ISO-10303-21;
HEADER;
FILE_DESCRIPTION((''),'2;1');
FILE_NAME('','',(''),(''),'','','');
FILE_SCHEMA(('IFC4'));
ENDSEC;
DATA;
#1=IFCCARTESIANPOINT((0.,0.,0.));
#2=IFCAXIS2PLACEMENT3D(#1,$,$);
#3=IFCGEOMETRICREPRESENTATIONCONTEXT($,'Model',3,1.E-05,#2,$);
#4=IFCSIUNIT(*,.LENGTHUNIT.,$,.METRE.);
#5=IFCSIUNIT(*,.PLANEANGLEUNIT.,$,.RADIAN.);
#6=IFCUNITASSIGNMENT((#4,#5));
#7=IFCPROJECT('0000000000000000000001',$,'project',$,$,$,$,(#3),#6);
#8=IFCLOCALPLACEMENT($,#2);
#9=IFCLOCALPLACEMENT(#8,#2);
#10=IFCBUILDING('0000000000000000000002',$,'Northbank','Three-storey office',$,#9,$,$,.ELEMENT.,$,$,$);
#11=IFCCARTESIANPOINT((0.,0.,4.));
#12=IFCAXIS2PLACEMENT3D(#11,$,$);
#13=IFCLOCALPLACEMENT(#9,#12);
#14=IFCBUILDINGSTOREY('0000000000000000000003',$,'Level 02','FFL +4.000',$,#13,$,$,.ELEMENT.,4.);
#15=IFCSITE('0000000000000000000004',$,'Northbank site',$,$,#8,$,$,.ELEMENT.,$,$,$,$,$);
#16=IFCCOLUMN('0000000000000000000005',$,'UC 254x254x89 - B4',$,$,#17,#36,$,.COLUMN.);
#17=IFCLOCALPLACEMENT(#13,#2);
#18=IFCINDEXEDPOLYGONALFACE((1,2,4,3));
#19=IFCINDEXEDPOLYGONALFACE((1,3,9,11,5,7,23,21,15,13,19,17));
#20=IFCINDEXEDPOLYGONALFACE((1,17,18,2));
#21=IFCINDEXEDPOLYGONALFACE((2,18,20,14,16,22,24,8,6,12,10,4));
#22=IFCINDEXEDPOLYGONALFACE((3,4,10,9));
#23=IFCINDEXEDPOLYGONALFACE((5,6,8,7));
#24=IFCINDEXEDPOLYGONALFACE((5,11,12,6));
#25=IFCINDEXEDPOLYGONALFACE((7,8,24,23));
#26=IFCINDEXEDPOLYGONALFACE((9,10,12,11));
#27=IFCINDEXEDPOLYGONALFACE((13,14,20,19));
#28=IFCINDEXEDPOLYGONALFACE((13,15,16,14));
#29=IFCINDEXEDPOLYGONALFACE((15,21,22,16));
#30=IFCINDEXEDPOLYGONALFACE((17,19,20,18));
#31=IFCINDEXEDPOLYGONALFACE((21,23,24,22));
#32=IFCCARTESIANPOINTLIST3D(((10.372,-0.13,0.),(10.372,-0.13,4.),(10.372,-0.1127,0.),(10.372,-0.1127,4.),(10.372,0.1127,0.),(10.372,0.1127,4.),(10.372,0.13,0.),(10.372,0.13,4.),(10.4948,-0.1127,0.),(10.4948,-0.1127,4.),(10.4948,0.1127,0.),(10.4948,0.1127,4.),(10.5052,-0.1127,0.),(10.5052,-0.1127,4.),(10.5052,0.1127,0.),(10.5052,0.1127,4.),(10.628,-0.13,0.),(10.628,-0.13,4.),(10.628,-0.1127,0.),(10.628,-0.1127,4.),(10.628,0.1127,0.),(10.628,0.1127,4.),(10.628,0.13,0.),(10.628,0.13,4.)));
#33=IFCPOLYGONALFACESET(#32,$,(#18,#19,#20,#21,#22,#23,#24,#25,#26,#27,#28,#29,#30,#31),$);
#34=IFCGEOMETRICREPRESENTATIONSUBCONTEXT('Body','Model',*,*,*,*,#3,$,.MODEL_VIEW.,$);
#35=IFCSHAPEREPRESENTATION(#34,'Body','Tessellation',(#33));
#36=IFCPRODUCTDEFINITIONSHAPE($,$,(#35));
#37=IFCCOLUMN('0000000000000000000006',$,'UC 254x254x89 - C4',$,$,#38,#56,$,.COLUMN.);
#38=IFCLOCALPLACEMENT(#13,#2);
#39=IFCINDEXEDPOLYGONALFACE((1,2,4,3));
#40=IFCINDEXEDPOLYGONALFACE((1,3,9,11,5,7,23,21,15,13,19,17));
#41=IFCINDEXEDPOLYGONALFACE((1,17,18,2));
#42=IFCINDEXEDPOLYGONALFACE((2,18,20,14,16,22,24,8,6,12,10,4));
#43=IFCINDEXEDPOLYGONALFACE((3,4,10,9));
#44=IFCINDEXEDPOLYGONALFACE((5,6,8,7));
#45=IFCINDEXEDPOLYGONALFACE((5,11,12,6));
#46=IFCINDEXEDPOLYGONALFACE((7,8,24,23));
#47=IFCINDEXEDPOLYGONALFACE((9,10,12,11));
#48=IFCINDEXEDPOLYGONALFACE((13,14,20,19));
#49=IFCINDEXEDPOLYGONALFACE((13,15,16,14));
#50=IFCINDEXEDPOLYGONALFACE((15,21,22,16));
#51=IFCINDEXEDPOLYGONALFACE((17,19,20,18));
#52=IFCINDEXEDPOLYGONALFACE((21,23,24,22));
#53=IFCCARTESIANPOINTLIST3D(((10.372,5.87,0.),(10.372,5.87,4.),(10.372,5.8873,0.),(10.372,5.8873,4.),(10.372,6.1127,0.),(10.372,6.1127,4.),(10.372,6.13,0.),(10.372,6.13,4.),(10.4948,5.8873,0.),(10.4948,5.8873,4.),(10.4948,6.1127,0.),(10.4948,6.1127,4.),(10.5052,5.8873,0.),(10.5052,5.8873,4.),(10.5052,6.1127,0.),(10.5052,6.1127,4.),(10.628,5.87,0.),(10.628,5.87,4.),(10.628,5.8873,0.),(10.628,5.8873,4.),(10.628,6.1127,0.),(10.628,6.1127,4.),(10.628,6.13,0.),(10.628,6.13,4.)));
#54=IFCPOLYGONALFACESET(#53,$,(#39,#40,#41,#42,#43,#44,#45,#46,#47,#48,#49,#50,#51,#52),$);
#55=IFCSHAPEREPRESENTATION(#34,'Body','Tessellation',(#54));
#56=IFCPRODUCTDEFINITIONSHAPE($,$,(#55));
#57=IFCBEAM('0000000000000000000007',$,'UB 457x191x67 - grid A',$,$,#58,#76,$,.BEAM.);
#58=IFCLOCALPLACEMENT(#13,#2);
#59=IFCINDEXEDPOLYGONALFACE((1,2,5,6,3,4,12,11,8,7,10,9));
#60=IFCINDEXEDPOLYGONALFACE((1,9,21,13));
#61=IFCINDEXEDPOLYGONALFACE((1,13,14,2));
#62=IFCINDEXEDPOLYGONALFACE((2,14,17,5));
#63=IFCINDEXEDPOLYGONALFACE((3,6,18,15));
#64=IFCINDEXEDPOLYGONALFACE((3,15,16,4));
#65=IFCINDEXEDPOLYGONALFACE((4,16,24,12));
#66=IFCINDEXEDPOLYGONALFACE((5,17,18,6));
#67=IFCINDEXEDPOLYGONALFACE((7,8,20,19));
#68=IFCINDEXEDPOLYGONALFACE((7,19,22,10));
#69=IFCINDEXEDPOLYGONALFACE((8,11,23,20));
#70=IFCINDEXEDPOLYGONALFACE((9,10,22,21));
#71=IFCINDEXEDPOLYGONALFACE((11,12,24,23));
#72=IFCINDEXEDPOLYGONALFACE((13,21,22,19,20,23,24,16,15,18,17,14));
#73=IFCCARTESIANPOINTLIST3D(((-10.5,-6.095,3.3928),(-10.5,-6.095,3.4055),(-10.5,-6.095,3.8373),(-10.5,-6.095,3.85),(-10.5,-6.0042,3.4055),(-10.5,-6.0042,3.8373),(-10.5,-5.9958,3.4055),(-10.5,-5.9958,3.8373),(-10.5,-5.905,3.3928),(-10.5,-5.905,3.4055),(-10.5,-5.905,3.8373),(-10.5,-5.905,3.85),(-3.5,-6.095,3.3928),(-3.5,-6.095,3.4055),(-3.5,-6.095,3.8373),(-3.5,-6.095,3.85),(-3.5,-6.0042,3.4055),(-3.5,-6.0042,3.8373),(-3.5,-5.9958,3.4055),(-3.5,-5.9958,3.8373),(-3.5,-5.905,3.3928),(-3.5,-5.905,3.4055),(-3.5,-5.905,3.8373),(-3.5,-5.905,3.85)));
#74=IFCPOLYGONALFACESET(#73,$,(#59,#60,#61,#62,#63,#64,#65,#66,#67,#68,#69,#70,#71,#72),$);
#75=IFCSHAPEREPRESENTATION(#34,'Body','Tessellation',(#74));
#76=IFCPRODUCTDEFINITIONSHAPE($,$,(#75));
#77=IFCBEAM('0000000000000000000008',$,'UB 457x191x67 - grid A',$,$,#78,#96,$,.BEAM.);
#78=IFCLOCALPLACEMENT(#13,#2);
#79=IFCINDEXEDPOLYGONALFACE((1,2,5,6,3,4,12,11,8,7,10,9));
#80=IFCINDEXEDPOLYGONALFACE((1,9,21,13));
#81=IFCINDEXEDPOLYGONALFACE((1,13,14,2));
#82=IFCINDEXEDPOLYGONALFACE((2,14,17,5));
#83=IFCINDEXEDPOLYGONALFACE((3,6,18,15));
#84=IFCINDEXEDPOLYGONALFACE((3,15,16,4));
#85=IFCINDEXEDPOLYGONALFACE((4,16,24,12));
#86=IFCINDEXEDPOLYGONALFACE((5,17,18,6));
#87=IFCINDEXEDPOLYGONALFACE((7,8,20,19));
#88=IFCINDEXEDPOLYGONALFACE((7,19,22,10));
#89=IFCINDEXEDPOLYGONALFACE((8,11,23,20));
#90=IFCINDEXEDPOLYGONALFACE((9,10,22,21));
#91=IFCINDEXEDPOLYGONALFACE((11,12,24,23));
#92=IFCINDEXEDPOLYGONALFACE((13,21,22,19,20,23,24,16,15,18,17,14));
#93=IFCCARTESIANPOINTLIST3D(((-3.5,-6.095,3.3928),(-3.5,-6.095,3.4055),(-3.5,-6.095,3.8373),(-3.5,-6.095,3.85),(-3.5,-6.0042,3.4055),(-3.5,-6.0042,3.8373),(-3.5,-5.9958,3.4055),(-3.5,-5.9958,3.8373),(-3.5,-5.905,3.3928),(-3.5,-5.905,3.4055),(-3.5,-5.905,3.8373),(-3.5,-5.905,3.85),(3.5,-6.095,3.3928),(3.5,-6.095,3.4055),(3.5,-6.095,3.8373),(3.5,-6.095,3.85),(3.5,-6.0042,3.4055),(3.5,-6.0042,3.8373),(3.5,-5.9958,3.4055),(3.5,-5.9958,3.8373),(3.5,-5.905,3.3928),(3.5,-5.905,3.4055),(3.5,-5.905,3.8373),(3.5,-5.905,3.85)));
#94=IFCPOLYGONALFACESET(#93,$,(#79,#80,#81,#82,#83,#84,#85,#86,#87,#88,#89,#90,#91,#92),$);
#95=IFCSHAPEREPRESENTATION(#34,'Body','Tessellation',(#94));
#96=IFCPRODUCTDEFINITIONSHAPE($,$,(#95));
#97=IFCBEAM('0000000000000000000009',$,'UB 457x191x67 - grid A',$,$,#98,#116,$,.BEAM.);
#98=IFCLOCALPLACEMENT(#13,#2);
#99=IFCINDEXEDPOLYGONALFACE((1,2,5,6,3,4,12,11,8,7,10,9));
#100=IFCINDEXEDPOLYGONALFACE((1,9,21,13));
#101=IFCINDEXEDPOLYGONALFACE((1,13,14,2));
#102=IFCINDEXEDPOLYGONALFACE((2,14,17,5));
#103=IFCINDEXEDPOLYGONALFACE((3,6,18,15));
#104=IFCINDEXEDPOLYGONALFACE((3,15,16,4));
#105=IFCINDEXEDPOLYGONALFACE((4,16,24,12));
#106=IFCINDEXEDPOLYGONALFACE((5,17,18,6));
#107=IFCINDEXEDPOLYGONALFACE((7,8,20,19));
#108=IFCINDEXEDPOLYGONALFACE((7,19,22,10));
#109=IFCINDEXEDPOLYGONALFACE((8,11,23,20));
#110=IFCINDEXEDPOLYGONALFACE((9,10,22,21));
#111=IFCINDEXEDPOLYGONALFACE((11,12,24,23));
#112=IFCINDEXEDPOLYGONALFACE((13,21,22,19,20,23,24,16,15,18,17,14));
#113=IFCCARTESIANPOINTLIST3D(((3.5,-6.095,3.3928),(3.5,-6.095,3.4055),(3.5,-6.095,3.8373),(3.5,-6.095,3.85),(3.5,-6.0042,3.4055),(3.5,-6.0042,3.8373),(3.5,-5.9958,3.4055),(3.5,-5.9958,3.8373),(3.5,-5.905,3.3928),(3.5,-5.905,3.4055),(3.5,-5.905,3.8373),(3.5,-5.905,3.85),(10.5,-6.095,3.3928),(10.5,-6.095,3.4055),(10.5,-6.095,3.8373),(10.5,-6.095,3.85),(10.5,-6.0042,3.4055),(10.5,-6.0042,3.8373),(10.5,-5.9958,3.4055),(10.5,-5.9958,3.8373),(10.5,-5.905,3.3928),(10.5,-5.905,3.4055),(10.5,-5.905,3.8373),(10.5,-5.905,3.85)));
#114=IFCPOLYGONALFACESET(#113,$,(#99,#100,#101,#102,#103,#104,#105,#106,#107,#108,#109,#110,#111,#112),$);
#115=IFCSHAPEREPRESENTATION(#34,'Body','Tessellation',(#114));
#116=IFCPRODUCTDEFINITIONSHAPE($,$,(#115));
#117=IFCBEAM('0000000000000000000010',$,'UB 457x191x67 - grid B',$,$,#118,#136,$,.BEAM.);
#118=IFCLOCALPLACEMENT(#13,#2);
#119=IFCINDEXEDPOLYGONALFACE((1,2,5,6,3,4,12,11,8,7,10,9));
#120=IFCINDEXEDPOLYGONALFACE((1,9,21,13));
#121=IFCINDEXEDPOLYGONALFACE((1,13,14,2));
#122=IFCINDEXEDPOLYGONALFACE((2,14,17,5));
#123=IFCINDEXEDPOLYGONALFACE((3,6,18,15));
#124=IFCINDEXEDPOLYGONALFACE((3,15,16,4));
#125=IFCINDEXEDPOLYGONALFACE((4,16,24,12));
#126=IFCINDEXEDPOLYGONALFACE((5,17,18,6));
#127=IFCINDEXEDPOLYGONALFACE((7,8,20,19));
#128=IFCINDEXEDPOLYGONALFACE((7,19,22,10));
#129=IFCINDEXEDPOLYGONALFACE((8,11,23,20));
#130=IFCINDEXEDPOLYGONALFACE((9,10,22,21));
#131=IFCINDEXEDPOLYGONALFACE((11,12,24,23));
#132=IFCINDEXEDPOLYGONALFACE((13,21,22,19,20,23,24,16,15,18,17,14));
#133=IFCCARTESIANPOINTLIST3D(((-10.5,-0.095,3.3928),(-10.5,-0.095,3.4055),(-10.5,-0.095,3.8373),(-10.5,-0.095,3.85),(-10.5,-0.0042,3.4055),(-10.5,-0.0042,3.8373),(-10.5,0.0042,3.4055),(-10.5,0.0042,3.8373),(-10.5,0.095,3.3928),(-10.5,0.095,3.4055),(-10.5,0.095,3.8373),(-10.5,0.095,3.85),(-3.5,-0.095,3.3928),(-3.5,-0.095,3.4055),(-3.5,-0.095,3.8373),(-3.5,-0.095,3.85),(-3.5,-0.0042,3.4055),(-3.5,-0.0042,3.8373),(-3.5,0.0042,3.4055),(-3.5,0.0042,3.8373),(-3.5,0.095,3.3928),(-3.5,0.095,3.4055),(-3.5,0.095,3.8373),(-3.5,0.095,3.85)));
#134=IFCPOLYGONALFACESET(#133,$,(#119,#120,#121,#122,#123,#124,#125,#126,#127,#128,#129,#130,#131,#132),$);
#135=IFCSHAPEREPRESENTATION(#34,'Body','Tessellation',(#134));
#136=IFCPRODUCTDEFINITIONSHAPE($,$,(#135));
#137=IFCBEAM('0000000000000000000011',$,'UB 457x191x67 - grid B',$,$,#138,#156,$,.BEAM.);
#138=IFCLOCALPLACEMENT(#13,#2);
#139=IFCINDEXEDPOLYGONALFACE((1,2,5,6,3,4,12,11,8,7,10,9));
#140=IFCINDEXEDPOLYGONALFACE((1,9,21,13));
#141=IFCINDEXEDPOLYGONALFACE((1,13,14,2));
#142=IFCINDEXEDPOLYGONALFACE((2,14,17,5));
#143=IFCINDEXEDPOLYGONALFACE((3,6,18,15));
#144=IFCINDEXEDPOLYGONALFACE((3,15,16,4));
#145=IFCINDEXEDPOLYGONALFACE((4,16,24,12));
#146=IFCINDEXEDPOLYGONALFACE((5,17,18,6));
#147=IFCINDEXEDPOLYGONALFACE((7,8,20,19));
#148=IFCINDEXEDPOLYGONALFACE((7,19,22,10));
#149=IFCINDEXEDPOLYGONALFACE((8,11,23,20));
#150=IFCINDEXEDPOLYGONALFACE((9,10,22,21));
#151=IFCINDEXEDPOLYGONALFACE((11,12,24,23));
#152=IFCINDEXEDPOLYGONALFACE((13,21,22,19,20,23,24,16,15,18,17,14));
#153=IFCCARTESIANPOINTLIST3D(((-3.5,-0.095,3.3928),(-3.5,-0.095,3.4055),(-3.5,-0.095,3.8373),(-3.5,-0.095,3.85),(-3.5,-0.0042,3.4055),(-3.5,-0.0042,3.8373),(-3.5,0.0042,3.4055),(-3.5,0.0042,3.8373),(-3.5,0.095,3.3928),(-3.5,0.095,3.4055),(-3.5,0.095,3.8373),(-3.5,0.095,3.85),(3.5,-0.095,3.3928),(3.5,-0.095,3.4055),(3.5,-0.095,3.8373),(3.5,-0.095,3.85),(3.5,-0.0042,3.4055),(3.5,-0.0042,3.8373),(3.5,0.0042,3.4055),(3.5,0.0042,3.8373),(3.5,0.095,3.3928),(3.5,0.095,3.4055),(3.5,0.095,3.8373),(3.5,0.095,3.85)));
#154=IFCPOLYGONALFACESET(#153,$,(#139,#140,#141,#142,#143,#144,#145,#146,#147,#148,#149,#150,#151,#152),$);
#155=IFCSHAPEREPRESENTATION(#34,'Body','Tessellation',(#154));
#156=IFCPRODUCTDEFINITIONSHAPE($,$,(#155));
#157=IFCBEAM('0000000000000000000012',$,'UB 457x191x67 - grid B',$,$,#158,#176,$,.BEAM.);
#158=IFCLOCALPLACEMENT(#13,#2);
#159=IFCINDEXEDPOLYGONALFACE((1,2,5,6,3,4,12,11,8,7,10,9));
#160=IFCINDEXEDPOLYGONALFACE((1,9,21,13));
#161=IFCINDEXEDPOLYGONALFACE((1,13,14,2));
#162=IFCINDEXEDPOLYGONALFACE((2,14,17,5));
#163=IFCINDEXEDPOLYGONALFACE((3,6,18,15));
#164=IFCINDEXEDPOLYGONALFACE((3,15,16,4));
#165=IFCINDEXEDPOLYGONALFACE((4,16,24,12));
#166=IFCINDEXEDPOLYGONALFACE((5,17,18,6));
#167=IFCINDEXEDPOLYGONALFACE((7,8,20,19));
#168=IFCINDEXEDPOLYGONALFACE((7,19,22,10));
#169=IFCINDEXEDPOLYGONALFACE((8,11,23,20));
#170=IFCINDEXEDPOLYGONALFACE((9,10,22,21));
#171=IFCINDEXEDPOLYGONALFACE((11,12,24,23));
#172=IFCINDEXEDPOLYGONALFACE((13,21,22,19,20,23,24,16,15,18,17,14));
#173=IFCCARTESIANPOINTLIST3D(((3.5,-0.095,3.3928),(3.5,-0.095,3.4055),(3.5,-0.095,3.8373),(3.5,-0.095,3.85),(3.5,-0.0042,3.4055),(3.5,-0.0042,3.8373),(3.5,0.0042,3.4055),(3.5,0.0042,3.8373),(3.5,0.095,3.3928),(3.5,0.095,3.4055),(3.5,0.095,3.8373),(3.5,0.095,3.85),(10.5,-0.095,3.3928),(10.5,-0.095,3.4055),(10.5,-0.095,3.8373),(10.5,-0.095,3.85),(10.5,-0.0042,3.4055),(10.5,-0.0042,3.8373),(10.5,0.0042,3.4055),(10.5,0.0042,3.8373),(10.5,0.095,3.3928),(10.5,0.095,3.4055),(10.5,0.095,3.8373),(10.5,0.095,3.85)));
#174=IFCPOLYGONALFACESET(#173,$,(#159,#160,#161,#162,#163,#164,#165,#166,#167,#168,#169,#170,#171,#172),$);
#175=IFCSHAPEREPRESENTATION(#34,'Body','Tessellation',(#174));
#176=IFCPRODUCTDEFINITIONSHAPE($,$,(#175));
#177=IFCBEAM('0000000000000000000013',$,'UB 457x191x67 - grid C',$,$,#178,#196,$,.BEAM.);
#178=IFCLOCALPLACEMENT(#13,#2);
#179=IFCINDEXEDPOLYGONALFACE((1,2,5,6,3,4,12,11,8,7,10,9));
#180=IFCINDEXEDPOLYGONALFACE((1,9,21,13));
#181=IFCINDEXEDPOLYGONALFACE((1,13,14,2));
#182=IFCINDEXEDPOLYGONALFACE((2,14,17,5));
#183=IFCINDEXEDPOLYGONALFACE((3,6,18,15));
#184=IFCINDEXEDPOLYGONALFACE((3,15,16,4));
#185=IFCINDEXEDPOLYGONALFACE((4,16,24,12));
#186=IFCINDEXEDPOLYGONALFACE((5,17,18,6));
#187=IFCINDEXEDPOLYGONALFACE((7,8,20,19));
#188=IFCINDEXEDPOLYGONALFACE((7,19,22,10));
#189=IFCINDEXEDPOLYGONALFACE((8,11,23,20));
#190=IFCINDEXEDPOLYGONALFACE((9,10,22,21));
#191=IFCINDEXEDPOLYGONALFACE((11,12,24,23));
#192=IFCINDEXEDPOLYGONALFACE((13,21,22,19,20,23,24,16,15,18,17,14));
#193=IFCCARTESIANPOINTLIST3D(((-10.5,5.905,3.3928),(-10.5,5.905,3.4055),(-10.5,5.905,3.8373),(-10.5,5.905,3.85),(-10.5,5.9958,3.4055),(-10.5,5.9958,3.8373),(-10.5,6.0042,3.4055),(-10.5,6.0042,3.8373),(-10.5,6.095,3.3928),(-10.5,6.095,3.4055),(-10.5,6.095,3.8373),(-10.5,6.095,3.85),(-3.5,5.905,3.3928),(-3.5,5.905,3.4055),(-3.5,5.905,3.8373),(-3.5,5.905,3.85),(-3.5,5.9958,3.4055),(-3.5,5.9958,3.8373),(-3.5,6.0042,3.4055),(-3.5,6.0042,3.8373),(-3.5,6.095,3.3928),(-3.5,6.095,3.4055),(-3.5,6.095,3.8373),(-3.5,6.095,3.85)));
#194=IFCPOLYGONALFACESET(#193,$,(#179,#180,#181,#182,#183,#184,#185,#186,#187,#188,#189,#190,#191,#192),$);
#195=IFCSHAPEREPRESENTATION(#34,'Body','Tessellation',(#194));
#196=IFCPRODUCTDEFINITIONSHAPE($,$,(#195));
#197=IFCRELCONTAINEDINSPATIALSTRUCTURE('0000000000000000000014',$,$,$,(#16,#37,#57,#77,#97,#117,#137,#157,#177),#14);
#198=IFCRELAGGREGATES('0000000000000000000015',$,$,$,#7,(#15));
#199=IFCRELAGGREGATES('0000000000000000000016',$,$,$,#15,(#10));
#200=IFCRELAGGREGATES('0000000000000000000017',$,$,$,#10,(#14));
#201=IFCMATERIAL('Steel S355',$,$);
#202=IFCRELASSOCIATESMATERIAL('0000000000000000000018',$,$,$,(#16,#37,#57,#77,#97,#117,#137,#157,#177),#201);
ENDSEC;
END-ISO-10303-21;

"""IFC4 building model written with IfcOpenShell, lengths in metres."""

from ifc_helpers import new_model, si_unit, frame, origin, place, context, subcontext, project, spatial, i_section, extrude, material, element, save


model = new_model("IFC4")

# Units and contexts
model_context = context("Model", 3, precision=1e-05, world=origin())
body_context = subcontext(model_context, "Body", "Model", "MODEL_VIEW")
ifc_project = project(units=[si_unit("LENGTHUNIT", "METRE"), si_unit("PLANEANGLEUNIT", "RADIAN")], contexts=[model_context])

# Site, building, storey
site_placement = place(None, origin())
site = spatial("IfcSite", under=ifc_project, at=site_placement, Name="Northbank site", CompositionType="ELEMENT")
building_placement = place(site_placement, origin())
building = spatial("IfcBuilding", under=site, at=building_placement, Name="Northbank", Description="Three-storey office", CompositionType="ELEMENT")
storey_placement = place(building_placement, frame((0.0, 0.0, 4.0)))
storey = spatial("IfcBuildingStorey", under=building, at=storey_placement, Name="Level 02", Description="FFL +4.000", CompositionType="ELEMENT", Elevation=4.0)

# Columns
ifc_material = material(Name="Steel S355")
column_1_placement = place(storey_placement, frame((0.0, 0.0, -4.0)))
element("IfcColumn", 1, at=column_1_placement, inside=storey, material=ifc_material, Name="UC 254x254x89 - B4", PredefinedType="COLUMN", context=body_context, shape_type="SweptSolid", body=[
    extrude(i_section(OverallWidth=0.256, OverallDepth=0.26, WebThickness=0.0103, FlangeThickness=0.0173), frame((10.5, 0.0, 4.0), z_axis=(0.0, 0.0, 1.0), x_axis=(1.0, 0.0, 0.0)), (0.0, 0.0, 1.0), 4.0),
])
column_2_placement = place(storey_placement, frame((0.0, 0.0, -4.0)))
element("IfcColumn", 2, at=column_2_placement, inside=storey, material=ifc_material, Name="UC 254x254x89 - C4", PredefinedType="COLUMN", context=body_context, shape_type="SweptSolid", body=[
    extrude(i_section(OverallWidth=0.256, OverallDepth=0.26, WebThickness=0.0103, FlangeThickness=0.0173), frame((10.5, 6.0, 4.0), z_axis=(0.0, 0.0, 1.0), x_axis=(1.0, 0.0, 0.0)), (0.0, 0.0, 1.0), 4.0),
])

# Beams
beam_1_placement = place(storey_placement, frame((0.0, 0.0, -4.0)))
element("IfcBeam", 3, at=beam_1_placement, inside=storey, material=ifc_material, Name="UB 457x191x67 - grid A", PredefinedType="BEAM", context=body_context, shape_type="SweptSolid", body=[
    extrude(i_section(OverallWidth=0.1899, OverallDepth=0.4572, WebThickness=0.0085, FlangeThickness=0.0127), frame((-10.5, -6.0, 7.6214), z_axis=(1.0, 0.0, 0.0), x_axis=(0.0, 1.0, 0.0)), (0.0, 0.0, 1.0), 7.0),
])
beam_2_placement = place(storey_placement, frame((0.0, 0.0, -4.0)))
element("IfcBeam", 4, at=beam_2_placement, inside=storey, material=ifc_material, Name="UB 457x191x67 - grid A", PredefinedType="BEAM", context=body_context, shape_type="SweptSolid", body=[
    extrude(i_section(OverallWidth=0.1899, OverallDepth=0.4572, WebThickness=0.0085, FlangeThickness=0.0127), frame((-3.5, -6.0, 7.6214), z_axis=(1.0, 0.0, 0.0), x_axis=(0.0, 1.0, 0.0)), (0.0, 0.0, 1.0), 7.0),
])
beam_3_placement = place(storey_placement, frame((0.0, 0.0, -4.0)))
element("IfcBeam", 5, at=beam_3_placement, inside=storey, material=ifc_material, Name="UB 457x191x67 - grid A", PredefinedType="BEAM", context=body_context, shape_type="SweptSolid", body=[
    extrude(i_section(OverallWidth=0.1899, OverallDepth=0.4572, WebThickness=0.0085, FlangeThickness=0.0127), frame((3.5, -6.0, 7.6214), z_axis=(1.0, 0.0, 0.0), x_axis=(0.0, 1.0, 0.0)), (0.0, 0.0, 1.0), 7.0),
])
beam_4_placement = place(storey_placement, frame((0.0, 0.0, -4.0)))
element("IfcBeam", 6, at=beam_4_placement, inside=storey, material=ifc_material, Name="UB 457x191x67 - grid B", PredefinedType="BEAM", context=body_context, shape_type="SweptSolid", body=[
    extrude(i_section(OverallWidth=0.1899, OverallDepth=0.4572, WebThickness=0.0085, FlangeThickness=0.0127), frame((-10.5, 0.0, 7.6214), z_axis=(1.0, 0.0, 0.0), x_axis=(0.0, 1.0, 0.0)), (0.0, 0.0, 1.0), 7.0),
])
beam_5_placement = place(storey_placement, frame((0.0, 0.0, -4.0)))
element("IfcBeam", 7, at=beam_5_placement, inside=storey, material=ifc_material, Name="UB 457x191x67 - grid B", PredefinedType="BEAM", context=body_context, shape_type="SweptSolid", body=[
    extrude(i_section(OverallWidth=0.1899, OverallDepth=0.4572, WebThickness=0.0085, FlangeThickness=0.0127), frame((-3.5, 0.0, 7.6214), z_axis=(1.0, 0.0, 0.0), x_axis=(0.0, 1.0, 0.0)), (0.0, 0.0, 1.0), 7.0),
])
beam_6_placement = place(storey_placement, frame((0.0, 0.0, -4.0)))
element("IfcBeam", 8, at=beam_6_placement, inside=storey, material=ifc_material, Name="UB 457x191x67 - grid B", PredefinedType="BEAM", context=body_context, shape_type="SweptSolid", body=[
    extrude(i_section(OverallWidth=0.1899, OverallDepth=0.4572, WebThickness=0.0085, FlangeThickness=0.0127), frame((3.5, 0.0, 7.6214), z_axis=(1.0, 0.0, 0.0), x_axis=(0.0, 1.0, 0.0)), (0.0, 0.0, 1.0), 7.0),
])
beam_7_placement = place(storey_placement, frame((0.0, 0.0, -4.0)))
element("IfcBeam", 9, at=beam_7_placement, inside=storey, material=ifc_material, Name="UB 457x191x67 - grid C", PredefinedType="BEAM", context=body_context, shape_type="SweptSolid", body=[
    extrude(i_section(OverallWidth=0.1899, OverallDepth=0.4572, WebThickness=0.0085, FlangeThickness=0.0127), frame((-10.5, 6.0, 7.6214), z_axis=(1.0, 0.0, 0.0), x_axis=(0.0, 1.0, 0.0)), (0.0, 0.0, 1.0), 7.0),
])

save(model, "model.ifc")
